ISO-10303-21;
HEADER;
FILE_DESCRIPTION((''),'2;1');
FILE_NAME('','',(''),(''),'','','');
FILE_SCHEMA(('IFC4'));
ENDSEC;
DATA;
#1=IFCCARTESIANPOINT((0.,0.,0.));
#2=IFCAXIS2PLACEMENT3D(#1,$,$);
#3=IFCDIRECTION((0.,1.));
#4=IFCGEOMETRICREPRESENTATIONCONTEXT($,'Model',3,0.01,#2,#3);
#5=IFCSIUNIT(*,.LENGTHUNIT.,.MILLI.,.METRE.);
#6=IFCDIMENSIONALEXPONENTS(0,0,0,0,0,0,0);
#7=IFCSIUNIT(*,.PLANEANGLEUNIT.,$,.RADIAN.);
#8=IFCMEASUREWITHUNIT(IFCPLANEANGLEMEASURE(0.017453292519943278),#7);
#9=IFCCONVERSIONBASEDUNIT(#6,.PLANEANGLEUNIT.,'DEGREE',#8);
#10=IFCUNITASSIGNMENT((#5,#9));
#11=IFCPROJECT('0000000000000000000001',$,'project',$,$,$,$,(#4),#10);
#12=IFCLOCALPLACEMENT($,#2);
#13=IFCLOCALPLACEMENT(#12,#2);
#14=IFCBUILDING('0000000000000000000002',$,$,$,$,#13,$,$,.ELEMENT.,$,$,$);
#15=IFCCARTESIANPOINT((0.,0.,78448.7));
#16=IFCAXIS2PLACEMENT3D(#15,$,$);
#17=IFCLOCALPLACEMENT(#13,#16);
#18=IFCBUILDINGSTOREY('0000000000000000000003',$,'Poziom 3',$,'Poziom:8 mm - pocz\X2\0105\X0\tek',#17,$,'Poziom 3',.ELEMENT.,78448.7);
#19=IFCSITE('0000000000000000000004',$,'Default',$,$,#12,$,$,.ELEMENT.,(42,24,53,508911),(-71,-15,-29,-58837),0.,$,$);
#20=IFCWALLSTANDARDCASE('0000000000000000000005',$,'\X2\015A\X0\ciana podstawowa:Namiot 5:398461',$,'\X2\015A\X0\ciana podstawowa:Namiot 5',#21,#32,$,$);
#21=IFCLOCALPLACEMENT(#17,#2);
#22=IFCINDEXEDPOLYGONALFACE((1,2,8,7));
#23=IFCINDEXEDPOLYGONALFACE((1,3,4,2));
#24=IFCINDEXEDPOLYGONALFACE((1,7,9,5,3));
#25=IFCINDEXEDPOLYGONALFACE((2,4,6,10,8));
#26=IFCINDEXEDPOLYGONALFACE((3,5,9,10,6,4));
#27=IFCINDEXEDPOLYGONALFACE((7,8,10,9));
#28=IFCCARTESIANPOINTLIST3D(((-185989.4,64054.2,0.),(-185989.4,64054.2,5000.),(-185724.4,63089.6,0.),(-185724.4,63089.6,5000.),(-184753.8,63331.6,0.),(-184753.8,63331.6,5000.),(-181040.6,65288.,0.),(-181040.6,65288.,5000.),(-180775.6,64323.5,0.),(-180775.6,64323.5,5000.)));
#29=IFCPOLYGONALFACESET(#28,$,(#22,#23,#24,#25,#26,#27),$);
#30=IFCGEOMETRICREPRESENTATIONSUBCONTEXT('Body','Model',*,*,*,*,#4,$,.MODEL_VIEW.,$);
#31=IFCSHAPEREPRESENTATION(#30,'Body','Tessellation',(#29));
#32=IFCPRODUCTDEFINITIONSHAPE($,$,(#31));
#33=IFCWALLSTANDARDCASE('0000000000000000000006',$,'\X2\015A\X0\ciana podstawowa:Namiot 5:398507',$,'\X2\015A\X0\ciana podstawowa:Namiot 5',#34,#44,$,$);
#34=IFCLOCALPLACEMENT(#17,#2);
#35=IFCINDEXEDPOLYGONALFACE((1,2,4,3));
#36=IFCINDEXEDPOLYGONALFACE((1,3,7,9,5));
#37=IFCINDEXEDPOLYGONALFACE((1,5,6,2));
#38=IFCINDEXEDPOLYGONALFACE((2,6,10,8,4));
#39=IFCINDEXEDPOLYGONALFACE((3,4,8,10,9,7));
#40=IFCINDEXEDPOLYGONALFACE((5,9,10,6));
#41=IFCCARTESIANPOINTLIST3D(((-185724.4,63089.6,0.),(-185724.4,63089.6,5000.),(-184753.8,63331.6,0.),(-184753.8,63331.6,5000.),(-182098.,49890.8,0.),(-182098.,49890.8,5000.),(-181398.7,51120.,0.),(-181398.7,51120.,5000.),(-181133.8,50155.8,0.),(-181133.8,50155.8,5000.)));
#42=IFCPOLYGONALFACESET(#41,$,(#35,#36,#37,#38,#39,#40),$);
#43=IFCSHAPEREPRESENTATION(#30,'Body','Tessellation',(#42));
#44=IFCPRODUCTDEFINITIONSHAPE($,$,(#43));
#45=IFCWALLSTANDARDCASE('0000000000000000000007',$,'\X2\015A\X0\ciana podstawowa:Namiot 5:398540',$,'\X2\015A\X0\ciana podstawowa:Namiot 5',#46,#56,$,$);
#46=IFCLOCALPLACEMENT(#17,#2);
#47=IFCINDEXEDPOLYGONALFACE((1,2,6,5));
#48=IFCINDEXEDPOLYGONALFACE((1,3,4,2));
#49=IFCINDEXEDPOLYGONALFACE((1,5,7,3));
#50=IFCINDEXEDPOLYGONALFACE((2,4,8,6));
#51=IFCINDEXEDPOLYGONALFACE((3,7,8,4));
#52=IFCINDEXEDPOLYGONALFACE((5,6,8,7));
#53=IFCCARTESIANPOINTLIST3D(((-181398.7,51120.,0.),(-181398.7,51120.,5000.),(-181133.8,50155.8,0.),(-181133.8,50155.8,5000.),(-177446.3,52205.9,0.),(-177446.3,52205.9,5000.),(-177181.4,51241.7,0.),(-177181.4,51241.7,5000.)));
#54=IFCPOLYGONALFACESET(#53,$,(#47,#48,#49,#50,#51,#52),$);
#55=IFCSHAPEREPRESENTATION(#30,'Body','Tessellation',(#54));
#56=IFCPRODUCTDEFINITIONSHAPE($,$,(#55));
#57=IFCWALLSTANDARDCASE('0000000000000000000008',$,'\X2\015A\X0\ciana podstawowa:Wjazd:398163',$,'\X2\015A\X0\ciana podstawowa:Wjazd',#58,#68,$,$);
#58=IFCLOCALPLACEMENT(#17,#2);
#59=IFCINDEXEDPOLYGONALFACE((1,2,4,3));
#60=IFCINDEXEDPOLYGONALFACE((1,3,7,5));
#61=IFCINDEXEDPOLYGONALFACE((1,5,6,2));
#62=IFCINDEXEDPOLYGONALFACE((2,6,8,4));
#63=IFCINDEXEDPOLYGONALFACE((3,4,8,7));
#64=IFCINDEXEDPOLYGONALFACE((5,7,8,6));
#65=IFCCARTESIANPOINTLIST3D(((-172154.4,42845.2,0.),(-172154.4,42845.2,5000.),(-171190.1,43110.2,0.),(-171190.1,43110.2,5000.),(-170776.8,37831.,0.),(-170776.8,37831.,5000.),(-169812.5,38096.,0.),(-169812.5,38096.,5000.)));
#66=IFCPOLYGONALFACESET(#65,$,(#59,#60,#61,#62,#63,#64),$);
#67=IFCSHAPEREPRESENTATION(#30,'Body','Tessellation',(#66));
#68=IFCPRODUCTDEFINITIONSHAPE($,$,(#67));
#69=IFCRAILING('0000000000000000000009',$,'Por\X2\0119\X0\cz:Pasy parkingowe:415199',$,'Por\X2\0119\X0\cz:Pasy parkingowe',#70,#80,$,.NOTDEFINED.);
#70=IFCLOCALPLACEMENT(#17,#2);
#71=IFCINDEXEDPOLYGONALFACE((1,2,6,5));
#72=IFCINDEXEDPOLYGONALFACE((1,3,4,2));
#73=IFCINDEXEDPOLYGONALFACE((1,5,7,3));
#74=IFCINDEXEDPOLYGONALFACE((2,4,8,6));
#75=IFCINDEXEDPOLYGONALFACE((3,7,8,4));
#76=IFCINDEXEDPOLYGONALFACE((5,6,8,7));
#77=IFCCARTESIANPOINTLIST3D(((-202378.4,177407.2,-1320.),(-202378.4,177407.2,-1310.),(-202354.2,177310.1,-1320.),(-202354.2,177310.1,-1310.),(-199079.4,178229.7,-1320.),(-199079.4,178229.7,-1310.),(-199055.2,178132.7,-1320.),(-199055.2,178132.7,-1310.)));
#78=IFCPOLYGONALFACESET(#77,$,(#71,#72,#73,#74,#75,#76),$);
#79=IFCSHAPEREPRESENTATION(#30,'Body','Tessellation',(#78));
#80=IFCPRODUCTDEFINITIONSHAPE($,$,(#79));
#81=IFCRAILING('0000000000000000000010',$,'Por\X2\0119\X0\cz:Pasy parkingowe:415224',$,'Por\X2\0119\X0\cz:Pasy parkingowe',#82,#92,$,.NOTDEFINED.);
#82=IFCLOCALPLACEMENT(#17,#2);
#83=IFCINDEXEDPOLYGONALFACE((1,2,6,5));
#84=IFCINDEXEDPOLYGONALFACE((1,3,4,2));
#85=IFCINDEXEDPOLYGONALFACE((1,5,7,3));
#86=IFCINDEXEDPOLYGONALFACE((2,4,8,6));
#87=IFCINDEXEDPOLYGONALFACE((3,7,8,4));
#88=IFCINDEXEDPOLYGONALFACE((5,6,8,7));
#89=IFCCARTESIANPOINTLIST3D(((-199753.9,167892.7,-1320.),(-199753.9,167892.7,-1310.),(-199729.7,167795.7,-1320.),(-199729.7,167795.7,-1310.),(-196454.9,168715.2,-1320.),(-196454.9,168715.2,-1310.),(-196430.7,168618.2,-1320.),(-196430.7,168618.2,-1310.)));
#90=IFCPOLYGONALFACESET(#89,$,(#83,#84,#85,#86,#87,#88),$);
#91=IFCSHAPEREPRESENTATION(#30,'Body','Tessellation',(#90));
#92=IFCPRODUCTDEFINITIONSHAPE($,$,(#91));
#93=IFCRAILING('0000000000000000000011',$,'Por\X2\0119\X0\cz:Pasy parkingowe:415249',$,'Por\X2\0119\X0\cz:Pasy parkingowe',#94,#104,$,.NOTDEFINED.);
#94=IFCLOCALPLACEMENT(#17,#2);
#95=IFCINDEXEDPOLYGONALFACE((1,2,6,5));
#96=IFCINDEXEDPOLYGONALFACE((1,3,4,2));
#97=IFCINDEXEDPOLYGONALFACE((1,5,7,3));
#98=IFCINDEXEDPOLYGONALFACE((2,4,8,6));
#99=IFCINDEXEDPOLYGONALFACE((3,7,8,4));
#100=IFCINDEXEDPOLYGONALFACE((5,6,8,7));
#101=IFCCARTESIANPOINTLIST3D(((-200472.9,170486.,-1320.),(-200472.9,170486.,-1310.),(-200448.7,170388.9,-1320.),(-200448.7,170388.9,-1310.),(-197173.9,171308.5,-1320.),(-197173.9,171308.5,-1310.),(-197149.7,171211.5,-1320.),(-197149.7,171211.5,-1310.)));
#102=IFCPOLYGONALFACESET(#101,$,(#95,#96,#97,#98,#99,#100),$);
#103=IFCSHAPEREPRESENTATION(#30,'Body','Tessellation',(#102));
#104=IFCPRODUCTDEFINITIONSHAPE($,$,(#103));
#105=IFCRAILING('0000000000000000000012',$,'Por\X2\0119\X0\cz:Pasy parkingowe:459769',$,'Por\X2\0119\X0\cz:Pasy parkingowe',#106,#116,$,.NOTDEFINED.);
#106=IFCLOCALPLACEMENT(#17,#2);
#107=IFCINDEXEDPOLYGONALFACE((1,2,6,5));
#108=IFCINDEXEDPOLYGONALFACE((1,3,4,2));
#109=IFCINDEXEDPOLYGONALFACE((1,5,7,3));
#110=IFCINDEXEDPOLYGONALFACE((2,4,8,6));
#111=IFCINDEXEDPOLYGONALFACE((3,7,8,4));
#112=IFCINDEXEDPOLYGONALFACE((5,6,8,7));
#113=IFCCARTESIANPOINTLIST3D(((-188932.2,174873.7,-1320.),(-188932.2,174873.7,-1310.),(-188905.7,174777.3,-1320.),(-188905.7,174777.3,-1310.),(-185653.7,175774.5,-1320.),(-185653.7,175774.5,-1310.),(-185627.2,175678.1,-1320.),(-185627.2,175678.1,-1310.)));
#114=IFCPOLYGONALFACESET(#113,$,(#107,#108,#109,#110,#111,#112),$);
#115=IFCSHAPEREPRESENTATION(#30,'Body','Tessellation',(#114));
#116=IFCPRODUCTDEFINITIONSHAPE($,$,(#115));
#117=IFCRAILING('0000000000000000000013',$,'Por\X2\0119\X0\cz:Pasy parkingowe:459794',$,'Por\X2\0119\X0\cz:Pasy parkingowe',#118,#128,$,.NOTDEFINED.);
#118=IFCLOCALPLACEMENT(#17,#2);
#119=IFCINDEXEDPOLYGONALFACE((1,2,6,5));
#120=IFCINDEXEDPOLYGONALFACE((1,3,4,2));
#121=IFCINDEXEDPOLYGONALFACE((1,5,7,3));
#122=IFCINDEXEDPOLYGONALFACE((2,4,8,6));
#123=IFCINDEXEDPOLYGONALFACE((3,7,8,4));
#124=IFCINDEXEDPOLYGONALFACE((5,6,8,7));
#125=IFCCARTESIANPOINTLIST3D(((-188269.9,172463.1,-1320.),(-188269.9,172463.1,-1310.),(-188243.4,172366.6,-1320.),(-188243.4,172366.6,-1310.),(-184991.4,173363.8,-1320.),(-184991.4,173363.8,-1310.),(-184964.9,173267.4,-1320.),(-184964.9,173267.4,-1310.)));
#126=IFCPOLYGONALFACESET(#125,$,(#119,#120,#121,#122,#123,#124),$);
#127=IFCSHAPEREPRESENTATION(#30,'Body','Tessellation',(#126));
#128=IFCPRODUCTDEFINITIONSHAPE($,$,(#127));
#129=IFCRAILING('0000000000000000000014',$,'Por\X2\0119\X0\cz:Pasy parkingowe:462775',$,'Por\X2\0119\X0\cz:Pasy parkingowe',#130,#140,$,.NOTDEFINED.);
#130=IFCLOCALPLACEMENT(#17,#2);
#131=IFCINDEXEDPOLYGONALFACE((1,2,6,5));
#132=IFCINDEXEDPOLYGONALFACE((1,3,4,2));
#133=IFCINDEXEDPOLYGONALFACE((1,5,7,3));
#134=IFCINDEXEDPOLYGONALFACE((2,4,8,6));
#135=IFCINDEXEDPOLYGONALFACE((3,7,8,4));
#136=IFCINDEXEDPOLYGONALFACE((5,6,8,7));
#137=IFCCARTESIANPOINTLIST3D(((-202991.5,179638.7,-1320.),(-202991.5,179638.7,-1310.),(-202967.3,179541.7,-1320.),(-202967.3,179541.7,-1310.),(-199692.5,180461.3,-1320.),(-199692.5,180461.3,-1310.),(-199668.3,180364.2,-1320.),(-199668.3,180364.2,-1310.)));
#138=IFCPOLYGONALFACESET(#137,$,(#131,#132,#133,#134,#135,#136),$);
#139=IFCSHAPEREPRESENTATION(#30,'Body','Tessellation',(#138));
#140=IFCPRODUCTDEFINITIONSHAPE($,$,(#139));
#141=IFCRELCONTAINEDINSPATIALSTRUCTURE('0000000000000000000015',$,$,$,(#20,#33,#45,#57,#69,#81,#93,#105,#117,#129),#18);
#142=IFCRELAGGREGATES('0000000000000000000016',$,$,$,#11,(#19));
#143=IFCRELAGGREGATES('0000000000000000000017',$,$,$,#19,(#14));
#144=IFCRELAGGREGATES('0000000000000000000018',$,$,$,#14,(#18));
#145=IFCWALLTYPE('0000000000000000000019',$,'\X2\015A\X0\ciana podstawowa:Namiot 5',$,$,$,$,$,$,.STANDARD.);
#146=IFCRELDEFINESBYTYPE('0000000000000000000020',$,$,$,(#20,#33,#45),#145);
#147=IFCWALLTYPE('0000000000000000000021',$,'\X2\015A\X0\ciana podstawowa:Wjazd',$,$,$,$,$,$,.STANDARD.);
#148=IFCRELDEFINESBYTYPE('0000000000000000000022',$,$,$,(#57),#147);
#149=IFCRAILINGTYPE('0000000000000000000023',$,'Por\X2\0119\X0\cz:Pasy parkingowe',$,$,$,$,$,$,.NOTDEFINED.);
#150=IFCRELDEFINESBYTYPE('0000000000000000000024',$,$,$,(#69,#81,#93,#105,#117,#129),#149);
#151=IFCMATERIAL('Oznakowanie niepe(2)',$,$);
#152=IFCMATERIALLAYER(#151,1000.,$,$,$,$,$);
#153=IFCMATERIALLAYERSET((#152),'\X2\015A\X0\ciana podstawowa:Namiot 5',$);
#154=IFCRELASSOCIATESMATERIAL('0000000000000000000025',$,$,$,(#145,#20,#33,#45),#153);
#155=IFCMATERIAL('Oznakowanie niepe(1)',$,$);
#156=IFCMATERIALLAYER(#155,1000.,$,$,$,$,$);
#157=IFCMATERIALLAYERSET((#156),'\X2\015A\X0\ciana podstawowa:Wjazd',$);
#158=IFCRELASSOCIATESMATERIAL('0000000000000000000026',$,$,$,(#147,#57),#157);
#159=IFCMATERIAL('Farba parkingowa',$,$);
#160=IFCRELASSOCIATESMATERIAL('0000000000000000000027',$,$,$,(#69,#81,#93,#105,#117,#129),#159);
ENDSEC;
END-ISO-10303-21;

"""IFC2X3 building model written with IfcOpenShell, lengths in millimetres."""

from ifc_helpers import new_model, entity, si_unit, converted_unit, direction, frame, frame_2d, origin, origin_2d_with_axis, place, context, subcontext, project, spatial, polyline, rectangle, outline, extrude, material, layer, layer_set, layer_usage, type_object, element, save


model = new_model("IFC2X3")

# Units and contexts
model_context = context("Model", 3, precision=0.01, world=origin(), true_north=direction((0.0, 1.0)))
body_context = subcontext(model_context, "Body", "Model", "MODEL_VIEW")
ifc_project = project(units=[si_unit("LENGTHUNIT", "METRE", prefix="MILLI"), converted_unit("PLANEANGLEUNIT", "DEGREE", entity("IfcPlaneAngleMeasure", 0.017453292519943278), si_unit("PLANEANGLEUNIT", "RADIAN"), dimensions=[0, 0, 0, 0, 0, 0, 0])], contexts=[model_context])

# Site, building, storey
site_placement = place(None, origin())
site = spatial("IfcSite", under=ifc_project, at=site_placement, Name="Default", CompositionType="ELEMENT", RefLatitude=(42, 24, 53, 508911), RefLongitude=(-71, -15, -29, -58837), RefElevation=0.0)
building_placement = place(site_placement, origin())
building = spatial("IfcBuilding", under=site, at=building_placement, CompositionType="ELEMENT")
storey_placement = place(building_placement, frame((0.0, 0.0, 78448.7)))
storey = spatial("IfcBuildingStorey", under=building, at=storey_placement, Name="Poziom 3", ObjectType="Poziom:8 mm - początek", LongName="Poziom 3", CompositionType="ELEMENT", Elevation=78448.7)

# Walls
ifc_material_1 = material(Name="Oznakowanie niepe(2)")
ifc_layer_1 = layer(ifc_material_1, 1000.0)
ifc_layer_set_1 = layer_set([ifc_layer_1], Name="Ściana podstawowa:Namiot 5")
wall_type_1 = type_object("IfcWallType", Name="Ściana podstawowa:Namiot 5", PredefinedType="STANDARD", material=ifc_layer_set_1)
ifc_layer_usage_1 = layer_usage(ifc_layer_set_1, "AXIS2", "NEGATIVE", 500.0)
wall_1_placement = place(storey_placement, frame((-180896.6, 64808.6, 0.0), z_axis=(0.0, 0.0, 1.0), x_axis=(-0.970296, -0.241922, 0.0)))
element("IfcWallStandardCase", 1, at=wall_1_placement, inside=storey, type_object=wall_type_1, material=ifc_layer_usage_1, Name="Ściana podstawowa:Namiot 5:398461", ObjectType="Ściana podstawowa:Namiot 5", context=body_context, shape_type="SweptSolid", body=[
    extrude(outline(polyline([(5124.1, -500.0), (5100.3, 500.0), (4100.0, 500.0), (0.0, 500.0), (23.8, -500.0), (5124.1, -500.0)])), origin(), (0.0, 0.0, 1.0), 5000.0),
])
ifc_layer_usage_2 = layer_usage(ifc_layer_set_1, "AXIS2", "NEGATIVE", 500.0)
wall_2_placement = place(storey_placement, frame((-185242.2, 63222.1, 0.0), z_axis=(0.0, 0.0, 1.0), x_axis=(0.264931, -0.964267, 0.0)))
element("IfcWallStandardCase", 2, at=wall_2_placement, inside=storey, type_object=wall_type_1, material=ifc_layer_usage_2, Name="Ściana podstawowa:Namiot 5:398507", ObjectType="Ściana podstawowa:Namiot 5", context=body_context, shape_type="SweptSolid", body=[
    extrude(outline(polyline([(13687.9, -500.0), (13687.9, 500.0), (12687.9, 500.0), (23.8, 500.0), (0.0, -500.0), (13687.9, -500.0)])), origin(), (0.0, 0.0, 1.0), 5000.0),
])
ifc_layer_usage_3 = layer_usage(ifc_layer_set_1, "AXIS2", "NEGATIVE", 500.0)
wall_3_placement = place(storey_placement, frame((-181266.2, 50637.9, 0.0), z_axis=(0.0, 0.0, 1.0), x_axis=(0.964267, 0.264931, 0.0)))
element("IfcWallStandardCase", 3, at=wall_3_placement, inside=storey, type_object=wall_type_1, material=ifc_layer_usage_3, Name="Ściana podstawowa:Namiot 5:398540", ObjectType="Ściana podstawowa:Namiot 5", context=body_context, shape_type="SweptSolid", body=[
    extrude(rectangle(XDim=1000.0, YDim=4098.8, at=frame_2d((0.0, 0.0), x_axis=(1.0, 0.0))), frame((2049.4, 0.0, 0.0), z_axis=(0.0, 0.0, 1.0), x_axis=(0.0, 1.0, 0.0)), (0.0, 0.0, 1.0), 5000.0),
])
ifc_material_2 = material(Name="Oznakowanie niepe(1)")
ifc_layer_2 = layer(ifc_material_2, 1000.0)
ifc_layer_set_2 = layer_set([ifc_layer_2], Name="Ściana podstawowa:Wjazd")
ifc_layer_usage_4 = layer_usage(ifc_layer_set_2, "AXIS2", "NEGATIVE", 500.0)
wall_type_2 = type_object("IfcWallType", Name="Ściana podstawowa:Wjazd", PredefinedType="STANDARD", material=ifc_layer_set_2)
wall_4_placement = place(storey_placement, frame((-171672.3, 42977.7, 0.0), z_axis=(0.0, 0.0, 1.0), x_axis=(0.264931, -0.964267, 0.0)))
element("IfcWallStandardCase", 4, at=wall_4_placement, inside=storey, type_object=wall_type_2, material=ifc_layer_usage_4, Name="Ściana podstawowa:Wjazd:398163", ObjectType="Ściana podstawowa:Wjazd", context=body_context, shape_type="SweptSolid", body=[
    extrude(rectangle(XDim=5200.0, YDim=1000.0, at=frame_2d((2600.0, 0.0), x_axis=(-1.0, 0.0))), origin(), (0.0, 0.0, 1.0), 5000.0),
])

# Railings
ifc_material_3 = material(Name="Farba parkingowa")
railing_type = type_object("IfcRailingType", Name="Poręcz:Pasy parkingowe", PredefinedType="NOTDEFINED")
railing_1_placement = place(storey_placement, origin())
element("IfcRailing", 5, at=railing_1_placement, inside=storey, type_object=railing_type, material=ifc_material_3, Name="Poręcz:Pasy parkingowe:415199", ObjectType="Poręcz:Pasy parkingowe", PredefinedType="NOTDEFINED", context=body_context, shape_type="SweptSolid", body=[
    extrude(rectangle(XDim=3400.0, YDim=100.0, at=frame_2d((0.0, 0.0), x_axis=(1.0, 0.0))), frame((-200716.8, 177769.9, -1320.0), z_axis=(0.0, 0.0, 1.0), x_axis=(0.970296, 0.241922, 0.0)), (0.0, 0.0, 1.0), 10.0),
])
railing_2_placement = place(storey_placement, origin())
element("IfcRailing", 6, at=railing_2_placement, inside=storey, type_object=railing_type, material=ifc_material_3, Name="Poręcz:Pasy parkingowe:415224", ObjectType="Poręcz:Pasy parkingowe", PredefinedType="NOTDEFINED", context=body_context, shape_type="SweptSolid", body=[
    extrude(rectangle(XDim=3400.0, YDim=100.0, at=origin_2d_with_axis()), frame((-198092.3, 168255.4, -1320.0), z_axis=(0.0, 0.0, 1.0), x_axis=(0.970296, 0.241922, 0.0)), (0.0, 0.0, 1.0), 10.0),
])
railing_3_placement = place(storey_placement, origin())
element("IfcRailing", 7, at=railing_3_placement, inside=storey, type_object=railing_type, material=ifc_material_3, Name="Poręcz:Pasy parkingowe:415249", ObjectType="Poręcz:Pasy parkingowe", PredefinedType="NOTDEFINED", context=body_context, shape_type="SweptSolid", body=[
    extrude(rectangle(XDim=3400.0, YDim=100.0, at=frame_2d((0.0, 0.0), x_axis=(1.0, 0.0))), frame((-198811.3, 170848.7, -1320.0), z_axis=(0.0, 0.0, 1.0), x_axis=(0.970296, 0.241922, 0.0)), (0.0, 0.0, 1.0), 10.0),
])
railing_4_placement = place(storey_placement, origin())
element("IfcRailing", 8, at=railing_4_placement, inside=storey, type_object=railing_type, material=ifc_material_3, Name="Poręcz:Pasy parkingowe:459769", ObjectType="Poręcz:Pasy parkingowe", PredefinedType="NOTDEFINED", context=body_context, shape_type="SweptSolid", body=[
    extrude(rectangle(XDim=3400.0, YDim=100.0, at=origin_2d_with_axis()), frame((-187279.7, 175275.9, -1320.0), z_axis=(0.0, 0.0, 1.0), x_axis=(0.964267, 0.264931, 0.0)), (0.0, 0.0, 1.0), 10.0),
])
railing_5_placement = place(storey_placement, origin())
element("IfcRailing", 9, at=railing_5_placement, inside=storey, type_object=railing_type, material=ifc_material_3, Name="Poręcz:Pasy parkingowe:459794", ObjectType="Poręcz:Pasy parkingowe", PredefinedType="NOTDEFINED", context=body_context, shape_type="SweptSolid", body=[
    extrude(rectangle(XDim=3400.0, YDim=100.0, at=frame_2d((0.0, 0.0), x_axis=(1.0, 0.0))), frame((-186617.4, 172865.2, -1320.0), z_axis=(0.0, 0.0, 1.0), x_axis=(0.964267, 0.264931, 0.0)), (0.0, 0.0, 1.0), 10.0),
])
railing_6_placement = place(storey_placement, origin())
element("IfcRailing", 10, at=railing_6_placement, inside=storey, type_object=railing_type, material=ifc_material_3, Name="Poręcz:Pasy parkingowe:462775", ObjectType="Poręcz:Pasy parkingowe", PredefinedType="NOTDEFINED", context=body_context, shape_type="SweptSolid", body=[
    extrude(rectangle(XDim=3400.0, YDim=100.0, at=frame_2d((0.0, 0.0), x_axis=(1.0, 0.0))), frame((-201329.9, 180001.5, -1320.0), z_axis=(0.0, 0.0, 1.0), x_axis=(0.970296, 0.241922, 0.0)), (0.0, 0.0, 1.0), 10.0),
])

save(model, "model.ifc")
